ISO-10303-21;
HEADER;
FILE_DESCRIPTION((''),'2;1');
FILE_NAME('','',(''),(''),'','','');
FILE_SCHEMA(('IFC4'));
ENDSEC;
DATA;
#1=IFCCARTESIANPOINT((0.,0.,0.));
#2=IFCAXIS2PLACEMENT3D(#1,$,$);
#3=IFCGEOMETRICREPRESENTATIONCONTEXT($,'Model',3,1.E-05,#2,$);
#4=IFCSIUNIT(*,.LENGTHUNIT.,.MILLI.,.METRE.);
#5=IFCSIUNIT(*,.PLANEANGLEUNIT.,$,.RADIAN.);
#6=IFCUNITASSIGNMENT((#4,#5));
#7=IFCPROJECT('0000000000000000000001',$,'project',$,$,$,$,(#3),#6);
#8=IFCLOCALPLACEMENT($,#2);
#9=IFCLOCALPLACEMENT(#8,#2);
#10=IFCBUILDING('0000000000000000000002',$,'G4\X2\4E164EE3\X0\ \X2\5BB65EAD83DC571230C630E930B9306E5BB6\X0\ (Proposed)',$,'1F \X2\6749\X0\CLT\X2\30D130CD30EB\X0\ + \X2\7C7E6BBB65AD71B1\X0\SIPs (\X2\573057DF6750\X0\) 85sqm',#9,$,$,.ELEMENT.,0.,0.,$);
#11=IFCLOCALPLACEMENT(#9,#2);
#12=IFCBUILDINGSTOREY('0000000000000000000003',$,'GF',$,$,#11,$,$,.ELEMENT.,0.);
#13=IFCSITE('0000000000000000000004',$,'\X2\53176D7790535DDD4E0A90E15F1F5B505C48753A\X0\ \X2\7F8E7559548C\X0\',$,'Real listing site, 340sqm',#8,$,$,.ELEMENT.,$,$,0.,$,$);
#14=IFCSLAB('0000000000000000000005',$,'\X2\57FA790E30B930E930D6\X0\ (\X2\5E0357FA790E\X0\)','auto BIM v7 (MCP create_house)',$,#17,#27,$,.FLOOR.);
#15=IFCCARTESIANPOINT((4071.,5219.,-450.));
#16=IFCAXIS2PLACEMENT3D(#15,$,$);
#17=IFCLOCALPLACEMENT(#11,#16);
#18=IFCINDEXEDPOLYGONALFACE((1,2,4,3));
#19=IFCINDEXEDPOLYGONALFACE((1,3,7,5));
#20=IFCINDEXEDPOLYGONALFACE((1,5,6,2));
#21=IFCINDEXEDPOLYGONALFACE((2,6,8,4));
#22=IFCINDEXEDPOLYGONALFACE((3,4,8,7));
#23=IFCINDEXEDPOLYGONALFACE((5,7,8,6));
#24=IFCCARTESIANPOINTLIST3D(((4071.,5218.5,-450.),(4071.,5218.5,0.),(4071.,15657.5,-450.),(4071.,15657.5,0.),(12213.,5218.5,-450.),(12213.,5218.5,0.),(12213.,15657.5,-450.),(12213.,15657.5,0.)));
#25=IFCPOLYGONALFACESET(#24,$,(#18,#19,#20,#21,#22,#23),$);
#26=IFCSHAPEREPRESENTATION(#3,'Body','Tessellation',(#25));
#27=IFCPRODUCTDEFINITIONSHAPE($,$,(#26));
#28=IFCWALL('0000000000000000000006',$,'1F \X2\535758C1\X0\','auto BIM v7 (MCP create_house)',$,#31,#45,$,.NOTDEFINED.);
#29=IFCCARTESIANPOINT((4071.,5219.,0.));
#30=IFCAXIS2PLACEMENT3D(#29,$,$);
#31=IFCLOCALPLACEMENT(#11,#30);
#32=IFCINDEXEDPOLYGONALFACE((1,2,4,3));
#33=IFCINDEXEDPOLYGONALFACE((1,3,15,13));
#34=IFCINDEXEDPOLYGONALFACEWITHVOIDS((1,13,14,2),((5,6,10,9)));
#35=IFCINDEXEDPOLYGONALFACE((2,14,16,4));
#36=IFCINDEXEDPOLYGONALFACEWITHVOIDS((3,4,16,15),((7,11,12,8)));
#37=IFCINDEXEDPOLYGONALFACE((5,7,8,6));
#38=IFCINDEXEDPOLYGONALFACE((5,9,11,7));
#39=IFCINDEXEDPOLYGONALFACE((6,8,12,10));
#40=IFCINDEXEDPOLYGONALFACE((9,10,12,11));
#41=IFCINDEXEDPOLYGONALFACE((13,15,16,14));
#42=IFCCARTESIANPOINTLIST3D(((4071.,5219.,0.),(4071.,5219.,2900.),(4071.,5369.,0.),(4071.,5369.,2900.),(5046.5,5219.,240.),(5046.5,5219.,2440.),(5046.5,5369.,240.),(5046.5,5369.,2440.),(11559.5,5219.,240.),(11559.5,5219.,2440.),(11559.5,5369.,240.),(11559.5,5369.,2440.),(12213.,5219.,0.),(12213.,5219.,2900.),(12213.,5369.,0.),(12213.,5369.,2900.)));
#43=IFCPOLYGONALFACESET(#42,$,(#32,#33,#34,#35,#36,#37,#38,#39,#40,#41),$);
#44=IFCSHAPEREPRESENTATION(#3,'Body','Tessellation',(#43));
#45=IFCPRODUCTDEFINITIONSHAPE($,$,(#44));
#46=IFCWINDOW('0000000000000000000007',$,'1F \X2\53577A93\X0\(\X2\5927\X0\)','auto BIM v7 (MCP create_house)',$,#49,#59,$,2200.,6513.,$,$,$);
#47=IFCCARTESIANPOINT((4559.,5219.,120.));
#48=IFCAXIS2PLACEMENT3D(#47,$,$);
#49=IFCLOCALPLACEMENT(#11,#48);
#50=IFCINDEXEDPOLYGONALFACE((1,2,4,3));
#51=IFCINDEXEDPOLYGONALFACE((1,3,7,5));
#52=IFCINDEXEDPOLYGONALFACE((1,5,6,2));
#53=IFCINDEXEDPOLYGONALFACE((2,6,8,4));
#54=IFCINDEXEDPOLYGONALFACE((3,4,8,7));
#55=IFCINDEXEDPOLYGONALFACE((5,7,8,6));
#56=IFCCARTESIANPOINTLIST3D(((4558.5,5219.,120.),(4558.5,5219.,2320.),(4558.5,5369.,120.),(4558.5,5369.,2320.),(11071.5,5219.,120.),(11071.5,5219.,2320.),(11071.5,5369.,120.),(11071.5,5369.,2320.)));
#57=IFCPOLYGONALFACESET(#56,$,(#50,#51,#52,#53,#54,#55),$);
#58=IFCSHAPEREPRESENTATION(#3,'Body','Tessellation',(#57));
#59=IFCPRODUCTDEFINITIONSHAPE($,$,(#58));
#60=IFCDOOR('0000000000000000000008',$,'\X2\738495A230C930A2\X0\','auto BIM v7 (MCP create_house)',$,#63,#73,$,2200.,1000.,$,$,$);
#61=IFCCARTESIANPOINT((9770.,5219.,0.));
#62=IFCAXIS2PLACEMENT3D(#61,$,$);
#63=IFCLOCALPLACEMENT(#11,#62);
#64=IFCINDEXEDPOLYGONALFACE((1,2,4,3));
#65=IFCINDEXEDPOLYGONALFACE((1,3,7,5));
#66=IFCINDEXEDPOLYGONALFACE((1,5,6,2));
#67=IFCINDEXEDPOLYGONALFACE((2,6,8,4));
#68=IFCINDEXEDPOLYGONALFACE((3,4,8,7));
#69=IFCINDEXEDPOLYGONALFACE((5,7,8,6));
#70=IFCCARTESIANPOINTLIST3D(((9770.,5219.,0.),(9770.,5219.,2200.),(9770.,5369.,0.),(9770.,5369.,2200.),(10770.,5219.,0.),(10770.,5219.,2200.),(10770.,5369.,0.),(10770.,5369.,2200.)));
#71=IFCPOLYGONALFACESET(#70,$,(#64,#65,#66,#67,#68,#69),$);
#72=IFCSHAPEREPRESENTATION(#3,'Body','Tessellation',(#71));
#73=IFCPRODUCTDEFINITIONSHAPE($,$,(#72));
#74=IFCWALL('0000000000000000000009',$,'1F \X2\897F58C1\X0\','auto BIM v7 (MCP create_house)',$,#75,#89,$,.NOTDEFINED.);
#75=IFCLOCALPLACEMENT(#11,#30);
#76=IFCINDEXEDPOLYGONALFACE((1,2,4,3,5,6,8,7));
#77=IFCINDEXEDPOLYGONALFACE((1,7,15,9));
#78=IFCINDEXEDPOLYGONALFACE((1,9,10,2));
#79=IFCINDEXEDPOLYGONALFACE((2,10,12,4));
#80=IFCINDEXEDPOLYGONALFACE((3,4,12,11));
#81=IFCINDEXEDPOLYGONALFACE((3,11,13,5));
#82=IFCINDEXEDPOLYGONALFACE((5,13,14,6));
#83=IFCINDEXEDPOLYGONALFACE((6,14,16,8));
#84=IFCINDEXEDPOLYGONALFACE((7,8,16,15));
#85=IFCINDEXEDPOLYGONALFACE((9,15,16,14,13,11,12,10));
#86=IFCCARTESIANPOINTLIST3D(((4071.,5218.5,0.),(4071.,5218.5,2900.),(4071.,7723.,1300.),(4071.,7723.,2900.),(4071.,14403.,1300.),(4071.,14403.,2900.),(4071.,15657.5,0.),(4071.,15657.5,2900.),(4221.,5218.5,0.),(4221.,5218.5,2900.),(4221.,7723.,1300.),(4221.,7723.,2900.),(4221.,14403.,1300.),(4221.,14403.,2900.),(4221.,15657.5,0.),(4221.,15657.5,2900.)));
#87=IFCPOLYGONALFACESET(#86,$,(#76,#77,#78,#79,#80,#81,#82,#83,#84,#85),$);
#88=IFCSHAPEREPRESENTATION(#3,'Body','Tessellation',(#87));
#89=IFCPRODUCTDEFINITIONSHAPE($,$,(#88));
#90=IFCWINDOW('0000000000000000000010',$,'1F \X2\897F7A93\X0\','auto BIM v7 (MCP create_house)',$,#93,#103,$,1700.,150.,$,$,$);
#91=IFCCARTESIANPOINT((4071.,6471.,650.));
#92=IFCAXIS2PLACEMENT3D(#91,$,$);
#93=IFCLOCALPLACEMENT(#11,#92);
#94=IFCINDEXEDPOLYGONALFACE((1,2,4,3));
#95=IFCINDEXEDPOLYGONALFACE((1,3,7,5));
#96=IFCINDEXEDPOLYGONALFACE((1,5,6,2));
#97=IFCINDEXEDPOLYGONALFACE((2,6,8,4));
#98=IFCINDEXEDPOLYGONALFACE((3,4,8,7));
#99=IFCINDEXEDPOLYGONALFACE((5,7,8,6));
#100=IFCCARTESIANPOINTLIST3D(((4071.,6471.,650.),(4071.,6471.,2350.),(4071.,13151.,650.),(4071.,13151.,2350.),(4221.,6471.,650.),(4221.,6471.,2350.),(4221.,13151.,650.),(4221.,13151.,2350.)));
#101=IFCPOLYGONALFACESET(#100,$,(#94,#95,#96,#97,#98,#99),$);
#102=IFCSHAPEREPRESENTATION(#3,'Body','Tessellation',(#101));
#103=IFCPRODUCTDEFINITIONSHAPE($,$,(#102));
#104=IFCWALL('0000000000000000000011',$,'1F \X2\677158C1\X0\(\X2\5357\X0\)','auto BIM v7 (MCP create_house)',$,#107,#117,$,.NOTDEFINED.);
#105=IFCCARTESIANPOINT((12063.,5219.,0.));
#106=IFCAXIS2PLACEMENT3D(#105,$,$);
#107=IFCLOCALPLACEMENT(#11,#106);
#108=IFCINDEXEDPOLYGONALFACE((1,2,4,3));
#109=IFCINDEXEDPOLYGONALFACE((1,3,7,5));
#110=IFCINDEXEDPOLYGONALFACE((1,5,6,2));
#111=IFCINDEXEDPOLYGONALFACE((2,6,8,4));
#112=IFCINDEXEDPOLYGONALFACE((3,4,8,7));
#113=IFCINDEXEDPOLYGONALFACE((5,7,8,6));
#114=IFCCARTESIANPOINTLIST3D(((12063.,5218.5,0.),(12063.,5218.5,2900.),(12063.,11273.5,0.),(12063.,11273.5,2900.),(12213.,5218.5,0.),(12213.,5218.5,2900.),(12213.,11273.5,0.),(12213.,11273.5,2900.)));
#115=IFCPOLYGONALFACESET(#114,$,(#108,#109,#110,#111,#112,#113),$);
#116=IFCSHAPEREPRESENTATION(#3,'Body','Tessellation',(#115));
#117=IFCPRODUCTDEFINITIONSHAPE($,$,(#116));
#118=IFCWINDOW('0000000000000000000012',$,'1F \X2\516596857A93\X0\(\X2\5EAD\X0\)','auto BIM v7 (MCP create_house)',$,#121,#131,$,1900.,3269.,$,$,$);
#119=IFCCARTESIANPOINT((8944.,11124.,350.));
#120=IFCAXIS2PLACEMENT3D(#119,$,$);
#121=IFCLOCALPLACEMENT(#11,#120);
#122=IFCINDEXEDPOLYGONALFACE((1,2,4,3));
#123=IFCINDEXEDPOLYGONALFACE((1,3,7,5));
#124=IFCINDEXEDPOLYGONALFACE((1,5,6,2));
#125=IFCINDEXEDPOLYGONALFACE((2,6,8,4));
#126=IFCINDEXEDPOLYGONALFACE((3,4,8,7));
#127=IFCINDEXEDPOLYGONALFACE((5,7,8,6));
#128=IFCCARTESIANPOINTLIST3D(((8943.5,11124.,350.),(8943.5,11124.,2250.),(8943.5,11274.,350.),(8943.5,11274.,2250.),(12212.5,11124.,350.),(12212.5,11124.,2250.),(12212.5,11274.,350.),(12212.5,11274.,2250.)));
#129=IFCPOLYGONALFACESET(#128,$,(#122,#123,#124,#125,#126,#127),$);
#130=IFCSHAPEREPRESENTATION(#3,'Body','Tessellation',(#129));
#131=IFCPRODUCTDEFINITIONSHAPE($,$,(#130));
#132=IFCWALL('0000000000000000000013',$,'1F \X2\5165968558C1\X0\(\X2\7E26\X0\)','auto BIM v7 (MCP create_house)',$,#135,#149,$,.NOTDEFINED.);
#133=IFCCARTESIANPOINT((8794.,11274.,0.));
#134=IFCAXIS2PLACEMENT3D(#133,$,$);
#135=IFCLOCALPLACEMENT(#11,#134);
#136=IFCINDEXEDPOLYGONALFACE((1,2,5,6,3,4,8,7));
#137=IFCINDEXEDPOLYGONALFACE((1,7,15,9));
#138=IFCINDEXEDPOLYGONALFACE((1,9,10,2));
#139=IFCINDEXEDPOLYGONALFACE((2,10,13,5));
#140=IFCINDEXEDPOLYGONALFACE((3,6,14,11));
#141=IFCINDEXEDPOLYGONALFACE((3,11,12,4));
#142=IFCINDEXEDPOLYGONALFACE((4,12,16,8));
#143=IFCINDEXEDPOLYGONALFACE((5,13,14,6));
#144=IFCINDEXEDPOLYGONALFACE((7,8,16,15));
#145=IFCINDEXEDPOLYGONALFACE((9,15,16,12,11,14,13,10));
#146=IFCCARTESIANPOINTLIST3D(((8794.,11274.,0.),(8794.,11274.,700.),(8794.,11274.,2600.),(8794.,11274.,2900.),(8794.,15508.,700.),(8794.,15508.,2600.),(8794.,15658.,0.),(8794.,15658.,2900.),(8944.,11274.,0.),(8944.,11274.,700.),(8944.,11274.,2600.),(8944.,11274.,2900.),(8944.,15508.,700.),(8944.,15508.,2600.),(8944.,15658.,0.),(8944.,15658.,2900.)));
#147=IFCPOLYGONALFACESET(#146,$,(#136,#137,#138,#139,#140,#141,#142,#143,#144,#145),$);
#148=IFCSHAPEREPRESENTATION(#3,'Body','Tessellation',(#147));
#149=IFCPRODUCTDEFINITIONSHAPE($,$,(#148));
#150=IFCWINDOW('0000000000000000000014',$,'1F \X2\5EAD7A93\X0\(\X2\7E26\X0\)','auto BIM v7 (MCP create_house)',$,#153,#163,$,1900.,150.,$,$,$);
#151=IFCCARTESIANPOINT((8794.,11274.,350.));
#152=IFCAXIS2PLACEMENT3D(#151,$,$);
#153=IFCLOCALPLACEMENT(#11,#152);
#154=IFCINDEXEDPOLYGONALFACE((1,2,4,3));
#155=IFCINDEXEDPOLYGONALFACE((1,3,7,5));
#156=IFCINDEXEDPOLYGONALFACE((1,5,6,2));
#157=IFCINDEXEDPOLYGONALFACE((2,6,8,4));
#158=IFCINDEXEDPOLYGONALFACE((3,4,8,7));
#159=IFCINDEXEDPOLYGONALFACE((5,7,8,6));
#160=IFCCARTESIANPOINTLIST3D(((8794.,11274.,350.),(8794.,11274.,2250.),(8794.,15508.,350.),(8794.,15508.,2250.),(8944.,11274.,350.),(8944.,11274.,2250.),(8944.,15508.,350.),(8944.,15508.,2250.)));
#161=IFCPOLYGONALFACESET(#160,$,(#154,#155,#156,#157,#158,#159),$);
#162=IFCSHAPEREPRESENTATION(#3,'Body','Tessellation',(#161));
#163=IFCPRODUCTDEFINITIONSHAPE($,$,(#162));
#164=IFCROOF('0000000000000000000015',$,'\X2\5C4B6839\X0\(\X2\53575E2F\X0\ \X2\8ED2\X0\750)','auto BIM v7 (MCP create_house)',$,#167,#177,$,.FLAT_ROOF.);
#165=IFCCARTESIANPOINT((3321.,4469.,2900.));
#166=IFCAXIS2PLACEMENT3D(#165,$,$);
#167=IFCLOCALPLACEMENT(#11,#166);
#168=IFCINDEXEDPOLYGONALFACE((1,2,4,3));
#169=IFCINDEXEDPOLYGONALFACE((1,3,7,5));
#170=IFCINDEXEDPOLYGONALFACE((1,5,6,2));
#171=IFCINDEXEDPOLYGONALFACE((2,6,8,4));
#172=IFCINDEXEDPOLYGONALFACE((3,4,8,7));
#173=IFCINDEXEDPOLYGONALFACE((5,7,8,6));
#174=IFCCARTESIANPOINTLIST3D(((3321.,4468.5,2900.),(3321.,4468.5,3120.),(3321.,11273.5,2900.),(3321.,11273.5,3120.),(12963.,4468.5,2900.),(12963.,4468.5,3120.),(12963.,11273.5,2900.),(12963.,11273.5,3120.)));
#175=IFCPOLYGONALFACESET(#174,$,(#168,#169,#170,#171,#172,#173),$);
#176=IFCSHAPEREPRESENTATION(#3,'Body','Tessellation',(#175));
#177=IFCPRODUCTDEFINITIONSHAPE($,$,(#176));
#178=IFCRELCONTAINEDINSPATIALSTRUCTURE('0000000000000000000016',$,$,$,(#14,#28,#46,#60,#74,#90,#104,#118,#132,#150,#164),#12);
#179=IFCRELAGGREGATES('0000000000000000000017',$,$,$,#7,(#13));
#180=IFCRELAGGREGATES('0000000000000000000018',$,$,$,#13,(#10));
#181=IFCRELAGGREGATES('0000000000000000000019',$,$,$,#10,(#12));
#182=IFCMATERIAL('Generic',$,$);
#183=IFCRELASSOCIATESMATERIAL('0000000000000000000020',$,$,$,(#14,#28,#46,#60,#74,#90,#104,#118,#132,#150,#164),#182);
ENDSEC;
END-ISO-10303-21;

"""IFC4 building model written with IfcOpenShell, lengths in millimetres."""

from ifc_helpers import new_model, si_unit, frame, frame_2d, origin, place, context, project, spatial, rectangle, extrude, material, element, fill, save


model = new_model("IFC4")

# Units and contexts
model_context = context("Model", 3, precision=1e-05, world=origin())
ifc_project = project(units=[si_unit("LENGTHUNIT", "METRE", prefix="MILLI"), si_unit("PLANEANGLEUNIT", "RADIAN")], contexts=[model_context])

# Site, building, storey
site_placement = place(None, origin())
site = spatial("IfcSite", under=ifc_project, at=site_placement, Name="北海道川上郡弟子屈町 美留和", ObjectType="Real listing site, 340sqm", CompositionType="ELEMENT", RefElevation=0.0)
building_placement = place(site_placement, origin())
building = spatial("IfcBuilding", under=site, at=building_placement, Name="G4世代 家庭菜園テラスの家 (Proposed)", ObjectType="1F 杉CLTパネル + 籾殻断熱SIPs (地域材) 85sqm", CompositionType="ELEMENT", ElevationOfRefHeight=0.0, ElevationOfTerrain=0.0)
storey_placement = place(building_placement, origin())
storey = spatial("IfcBuildingStorey", under=building, at=storey_placement, Name="GF", CompositionType="ELEMENT", Elevation=0.0)

# Slab
ifc_material = material(Name="Generic")
slab_1_placement = place(storey_placement, frame((4071.0, 5219.0, -450.0)))
element("IfcSlab", 1, at=slab_1_placement, inside=storey, material=ifc_material, Name="基礎スラブ (布基礎)", Description="auto BIM v7 (MCP create_house)", PredefinedType="FLOOR", context=model_context, shape_type="SweptSolid", body=[
    extrude(rectangle(XDim=8142.0, YDim=10439.0, at=frame_2d((4071.0, 5219.0))), frame((4071.0, 5219.0, -450.0)), (0.0, 0.0, 1.0), 450.0),
])

# Wall, openings, window, door
wall_1_placement = place(storey_placement, frame((4071.0, 5219.0, 0.0)))
wall_1 = element("IfcWall", 2, at=wall_1_placement, inside=storey, material=ifc_material, Name="1F 南壁", Description="auto BIM v7 (MCP create_house)", PredefinedType="NOTDEFINED", context=model_context, shape_type="SweptSolid", body=[
    extrude(rectangle(XDim=8142.0, YDim=150.0, at=frame_2d((4071.0, 75.0))), frame((4071.0, 5219.0, 0.0)), (0.0, 0.0, 1.0), 2900.0),
])
opening_1_placement = place(storey_placement, frame((4559.0, 5219.0, 120.0)))
opening_1 = element("IfcOpeningElement", 3, at=opening_1_placement, cuts=wall_1, PredefinedType="NOTDEFINED", context=model_context, shape_type="SweptSolid", body=[
    extrude(rectangle(XDim=6513.0, YDim=150.0, at=frame_2d((3256.0, 75.0))), frame((4559.0, 5219.0, 120.0)), (0.0, 0.0, 1.0), 2200.0),
])
opening_2_placement = place(storey_placement, frame((9770.0, 5219.0, 0.0)))
opening_2 = element("IfcOpeningElement", 4, at=opening_2_placement, cuts=wall_1, PredefinedType="NOTDEFINED", context=model_context, shape_type="SweptSolid", body=[
    extrude(rectangle(XDim=1000.0, YDim=150.0, at=frame_2d((500.0, 75.0))), frame((9770.0, 5219.0, 0.0)), (0.0, 0.0, 1.0), 2200.0),
])
window_1_placement = place(storey_placement, frame((4559.0, 5219.0, 120.0)))
window_1 = element("IfcWindow", 5, at=window_1_placement, inside=storey, material=ifc_material, Name="1F 南窓(大)", Description="auto BIM v7 (MCP create_house)", OverallHeight=2200.0, OverallWidth=6513.0, context=model_context, shape_type="SweptSolid", body=[
    extrude(rectangle(XDim=6513.0, YDim=150.0, at=frame_2d((3256.0, 75.0))), frame((4559.0, 5219.0, 120.0)), (0.0, 0.0, 1.0), 2200.0),
])
fill(opening_1, window_1)
door_placement = place(storey_placement, frame((9770.0, 5219.0, 0.0)))
door = element("IfcDoor", 6, at=door_placement, inside=storey, material=ifc_material, Name="玄関ドア", Description="auto BIM v7 (MCP create_house)", OverallHeight=2200.0, OverallWidth=1000.0, context=model_context, shape_type="SweptSolid", body=[
    extrude(rectangle(XDim=1000.0, YDim=150.0, at=frame_2d((500.0, 75.0))), frame((9770.0, 5219.0, 0.0)), (0.0, 0.0, 1.0), 2200.0),
])
fill(opening_2, door)

# Wall, opening, window
wall_2_placement = place(storey_placement, frame((4071.0, 5219.0, 0.0)))
wall_2 = element("IfcWall", 7, at=wall_2_placement, inside=storey, material=ifc_material, Name="1F 西壁", Description="auto BIM v7 (MCP create_house)", PredefinedType="NOTDEFINED", context=model_context, shape_type="SweptSolid", body=[
    extrude(rectangle(XDim=150.0, YDim=10439.0, at=frame_2d((75.0, 5219.0))), frame((4071.0, 5219.0, 0.0)), (0.0, 0.0, 1.0), 2900.0),
])
opening_3_placement = place(storey_placement, frame((4071.0, 6471.0, 650.0)))
opening_3 = element("IfcOpeningElement", 8, at=opening_3_placement, cuts=wall_2, PredefinedType="NOTDEFINED", context=model_context, shape_type="SweptSolid", body=[
    extrude(rectangle(XDim=150.0, YDim=6680.0, at=frame_2d((75.0, 3340.0))), frame((4071.0, 6471.0, 650.0)), (0.0, 0.0, 1.0), 1700.0),
])
window_2_placement = place(storey_placement, frame((4071.0, 6471.0, 650.0)))
window_2 = element("IfcWindow", 9, at=window_2_placement, inside=storey, material=ifc_material, Name="1F 西窓", Description="auto BIM v7 (MCP create_house)", OverallHeight=1700.0, OverallWidth=150.0, context=model_context, shape_type="SweptSolid", body=[
    extrude(rectangle(XDim=150.0, YDim=6680.0, at=frame_2d((75.0, 3340.0))), frame((4071.0, 6471.0, 650.0)), (0.0, 0.0, 1.0), 1700.0),
])
fill(opening_3, window_2)

# Wall, opening, window
wall_3_placement = place(storey_placement, frame((12063.0, 5219.0, 0.0)))
wall_3 = element("IfcWall", 10, at=wall_3_placement, inside=storey, material=ifc_material, Name="1F 東壁(南)", Description="auto BIM v7 (MCP create_house)", PredefinedType="NOTDEFINED", context=model_context, shape_type="SweptSolid", body=[
    extrude(rectangle(XDim=150.0, YDim=6055.0, at=frame_2d((75.0, 3027.0))), frame((12063.0, 5219.0, 0.0)), (0.0, 0.0, 1.0), 2900.0),
])
opening_4_placement = place(storey_placement, frame((8944.0, 11124.0, 350.0)))
opening_4 = element("IfcOpeningElement", 11, at=opening_4_placement, cuts=wall_3, PredefinedType="NOTDEFINED", context=model_context, shape_type="SweptSolid", body=[
    extrude(rectangle(XDim=3269.0, YDim=150.0, at=frame_2d((1634.0, 75.0))), frame((8944.0, 11124.0, 350.0)), (0.0, 0.0, 1.0), 1900.0),
])
window_3_placement = place(storey_placement, frame((8944.0, 11124.0, 350.0)))
window_3 = element("IfcWindow", 12, at=window_3_placement, inside=storey, material=ifc_material, Name="1F 入隅窓(庭)", Description="auto BIM v7 (MCP create_house)", OverallHeight=1900.0, OverallWidth=3269.0, context=model_context, shape_type="SweptSolid", body=[
    extrude(rectangle(XDim=3269.0, YDim=150.0, at=frame_2d((1634.0, 75.0))), frame((8944.0, 11124.0, 350.0)), (0.0, 0.0, 1.0), 1900.0),
])
fill(opening_4, window_3)

# Wall, opening, window
wall_4_placement = place(storey_placement, frame((8794.0, 11274.0, 0.0)))
wall_4 = element("IfcWall", 13, at=wall_4_placement, inside=storey, material=ifc_material, Name="1F 入隅壁(縦)", Description="auto BIM v7 (MCP create_house)", PredefinedType="NOTDEFINED", context=model_context, shape_type="SweptSolid", body=[
    extrude(rectangle(XDim=150.0, YDim=4384.0, at=frame_2d((75.0, 2192.0))), frame((8794.0, 11274.0, 0.0)), (0.0, 0.0, 1.0), 2900.0),
])
opening_5_placement = place(storey_placement, frame((8794.0, 11274.0, 350.0)))
opening_5 = element("IfcOpeningElement", 14, at=opening_5_placement, cuts=wall_4, PredefinedType="NOTDEFINED", context=model_context, shape_type="SweptSolid", body=[
    extrude(rectangle(XDim=150.0, YDim=4234.0, at=frame_2d((75.0, 2117.0))), frame((8794.0, 11274.0, 350.0)), (0.0, 0.0, 1.0), 1900.0),
])
window_4_placement = place(storey_placement, frame((8794.0, 11274.0, 350.0)))
window_4 = element("IfcWindow", 15, at=window_4_placement, inside=storey, material=ifc_material, Name="1F 庭窓(縦)", Description="auto BIM v7 (MCP create_house)", OverallHeight=1900.0, OverallWidth=150.0, context=model_context, shape_type="SweptSolid", body=[
    extrude(rectangle(XDim=150.0, YDim=4234.0, at=frame_2d((75.0, 2117.0))), frame((8794.0, 11274.0, 350.0)), (0.0, 0.0, 1.0), 1900.0),
])
fill(opening_5, window_4)

# Roof
roof_1_placement = place(storey_placement, frame((3321.0, 4469.0, 2900.0)))
element("IfcRoof", 16, at=roof_1_placement, inside=storey, material=ifc_material, Name="屋根(南帯 軒750)", Description="auto BIM v7 (MCP create_house)", PredefinedType="FLAT_ROOF", context=model_context, shape_type="SweptSolid", body=[
    extrude(rectangle(XDim=9642.0, YDim=6805.0, at=frame_2d((4821.0, 3402.0))), frame((3321.0, 4469.0, 2900.0)), (0.0, 0.0, 1.0), 220.0),
])

save(model, "model.ifc")
